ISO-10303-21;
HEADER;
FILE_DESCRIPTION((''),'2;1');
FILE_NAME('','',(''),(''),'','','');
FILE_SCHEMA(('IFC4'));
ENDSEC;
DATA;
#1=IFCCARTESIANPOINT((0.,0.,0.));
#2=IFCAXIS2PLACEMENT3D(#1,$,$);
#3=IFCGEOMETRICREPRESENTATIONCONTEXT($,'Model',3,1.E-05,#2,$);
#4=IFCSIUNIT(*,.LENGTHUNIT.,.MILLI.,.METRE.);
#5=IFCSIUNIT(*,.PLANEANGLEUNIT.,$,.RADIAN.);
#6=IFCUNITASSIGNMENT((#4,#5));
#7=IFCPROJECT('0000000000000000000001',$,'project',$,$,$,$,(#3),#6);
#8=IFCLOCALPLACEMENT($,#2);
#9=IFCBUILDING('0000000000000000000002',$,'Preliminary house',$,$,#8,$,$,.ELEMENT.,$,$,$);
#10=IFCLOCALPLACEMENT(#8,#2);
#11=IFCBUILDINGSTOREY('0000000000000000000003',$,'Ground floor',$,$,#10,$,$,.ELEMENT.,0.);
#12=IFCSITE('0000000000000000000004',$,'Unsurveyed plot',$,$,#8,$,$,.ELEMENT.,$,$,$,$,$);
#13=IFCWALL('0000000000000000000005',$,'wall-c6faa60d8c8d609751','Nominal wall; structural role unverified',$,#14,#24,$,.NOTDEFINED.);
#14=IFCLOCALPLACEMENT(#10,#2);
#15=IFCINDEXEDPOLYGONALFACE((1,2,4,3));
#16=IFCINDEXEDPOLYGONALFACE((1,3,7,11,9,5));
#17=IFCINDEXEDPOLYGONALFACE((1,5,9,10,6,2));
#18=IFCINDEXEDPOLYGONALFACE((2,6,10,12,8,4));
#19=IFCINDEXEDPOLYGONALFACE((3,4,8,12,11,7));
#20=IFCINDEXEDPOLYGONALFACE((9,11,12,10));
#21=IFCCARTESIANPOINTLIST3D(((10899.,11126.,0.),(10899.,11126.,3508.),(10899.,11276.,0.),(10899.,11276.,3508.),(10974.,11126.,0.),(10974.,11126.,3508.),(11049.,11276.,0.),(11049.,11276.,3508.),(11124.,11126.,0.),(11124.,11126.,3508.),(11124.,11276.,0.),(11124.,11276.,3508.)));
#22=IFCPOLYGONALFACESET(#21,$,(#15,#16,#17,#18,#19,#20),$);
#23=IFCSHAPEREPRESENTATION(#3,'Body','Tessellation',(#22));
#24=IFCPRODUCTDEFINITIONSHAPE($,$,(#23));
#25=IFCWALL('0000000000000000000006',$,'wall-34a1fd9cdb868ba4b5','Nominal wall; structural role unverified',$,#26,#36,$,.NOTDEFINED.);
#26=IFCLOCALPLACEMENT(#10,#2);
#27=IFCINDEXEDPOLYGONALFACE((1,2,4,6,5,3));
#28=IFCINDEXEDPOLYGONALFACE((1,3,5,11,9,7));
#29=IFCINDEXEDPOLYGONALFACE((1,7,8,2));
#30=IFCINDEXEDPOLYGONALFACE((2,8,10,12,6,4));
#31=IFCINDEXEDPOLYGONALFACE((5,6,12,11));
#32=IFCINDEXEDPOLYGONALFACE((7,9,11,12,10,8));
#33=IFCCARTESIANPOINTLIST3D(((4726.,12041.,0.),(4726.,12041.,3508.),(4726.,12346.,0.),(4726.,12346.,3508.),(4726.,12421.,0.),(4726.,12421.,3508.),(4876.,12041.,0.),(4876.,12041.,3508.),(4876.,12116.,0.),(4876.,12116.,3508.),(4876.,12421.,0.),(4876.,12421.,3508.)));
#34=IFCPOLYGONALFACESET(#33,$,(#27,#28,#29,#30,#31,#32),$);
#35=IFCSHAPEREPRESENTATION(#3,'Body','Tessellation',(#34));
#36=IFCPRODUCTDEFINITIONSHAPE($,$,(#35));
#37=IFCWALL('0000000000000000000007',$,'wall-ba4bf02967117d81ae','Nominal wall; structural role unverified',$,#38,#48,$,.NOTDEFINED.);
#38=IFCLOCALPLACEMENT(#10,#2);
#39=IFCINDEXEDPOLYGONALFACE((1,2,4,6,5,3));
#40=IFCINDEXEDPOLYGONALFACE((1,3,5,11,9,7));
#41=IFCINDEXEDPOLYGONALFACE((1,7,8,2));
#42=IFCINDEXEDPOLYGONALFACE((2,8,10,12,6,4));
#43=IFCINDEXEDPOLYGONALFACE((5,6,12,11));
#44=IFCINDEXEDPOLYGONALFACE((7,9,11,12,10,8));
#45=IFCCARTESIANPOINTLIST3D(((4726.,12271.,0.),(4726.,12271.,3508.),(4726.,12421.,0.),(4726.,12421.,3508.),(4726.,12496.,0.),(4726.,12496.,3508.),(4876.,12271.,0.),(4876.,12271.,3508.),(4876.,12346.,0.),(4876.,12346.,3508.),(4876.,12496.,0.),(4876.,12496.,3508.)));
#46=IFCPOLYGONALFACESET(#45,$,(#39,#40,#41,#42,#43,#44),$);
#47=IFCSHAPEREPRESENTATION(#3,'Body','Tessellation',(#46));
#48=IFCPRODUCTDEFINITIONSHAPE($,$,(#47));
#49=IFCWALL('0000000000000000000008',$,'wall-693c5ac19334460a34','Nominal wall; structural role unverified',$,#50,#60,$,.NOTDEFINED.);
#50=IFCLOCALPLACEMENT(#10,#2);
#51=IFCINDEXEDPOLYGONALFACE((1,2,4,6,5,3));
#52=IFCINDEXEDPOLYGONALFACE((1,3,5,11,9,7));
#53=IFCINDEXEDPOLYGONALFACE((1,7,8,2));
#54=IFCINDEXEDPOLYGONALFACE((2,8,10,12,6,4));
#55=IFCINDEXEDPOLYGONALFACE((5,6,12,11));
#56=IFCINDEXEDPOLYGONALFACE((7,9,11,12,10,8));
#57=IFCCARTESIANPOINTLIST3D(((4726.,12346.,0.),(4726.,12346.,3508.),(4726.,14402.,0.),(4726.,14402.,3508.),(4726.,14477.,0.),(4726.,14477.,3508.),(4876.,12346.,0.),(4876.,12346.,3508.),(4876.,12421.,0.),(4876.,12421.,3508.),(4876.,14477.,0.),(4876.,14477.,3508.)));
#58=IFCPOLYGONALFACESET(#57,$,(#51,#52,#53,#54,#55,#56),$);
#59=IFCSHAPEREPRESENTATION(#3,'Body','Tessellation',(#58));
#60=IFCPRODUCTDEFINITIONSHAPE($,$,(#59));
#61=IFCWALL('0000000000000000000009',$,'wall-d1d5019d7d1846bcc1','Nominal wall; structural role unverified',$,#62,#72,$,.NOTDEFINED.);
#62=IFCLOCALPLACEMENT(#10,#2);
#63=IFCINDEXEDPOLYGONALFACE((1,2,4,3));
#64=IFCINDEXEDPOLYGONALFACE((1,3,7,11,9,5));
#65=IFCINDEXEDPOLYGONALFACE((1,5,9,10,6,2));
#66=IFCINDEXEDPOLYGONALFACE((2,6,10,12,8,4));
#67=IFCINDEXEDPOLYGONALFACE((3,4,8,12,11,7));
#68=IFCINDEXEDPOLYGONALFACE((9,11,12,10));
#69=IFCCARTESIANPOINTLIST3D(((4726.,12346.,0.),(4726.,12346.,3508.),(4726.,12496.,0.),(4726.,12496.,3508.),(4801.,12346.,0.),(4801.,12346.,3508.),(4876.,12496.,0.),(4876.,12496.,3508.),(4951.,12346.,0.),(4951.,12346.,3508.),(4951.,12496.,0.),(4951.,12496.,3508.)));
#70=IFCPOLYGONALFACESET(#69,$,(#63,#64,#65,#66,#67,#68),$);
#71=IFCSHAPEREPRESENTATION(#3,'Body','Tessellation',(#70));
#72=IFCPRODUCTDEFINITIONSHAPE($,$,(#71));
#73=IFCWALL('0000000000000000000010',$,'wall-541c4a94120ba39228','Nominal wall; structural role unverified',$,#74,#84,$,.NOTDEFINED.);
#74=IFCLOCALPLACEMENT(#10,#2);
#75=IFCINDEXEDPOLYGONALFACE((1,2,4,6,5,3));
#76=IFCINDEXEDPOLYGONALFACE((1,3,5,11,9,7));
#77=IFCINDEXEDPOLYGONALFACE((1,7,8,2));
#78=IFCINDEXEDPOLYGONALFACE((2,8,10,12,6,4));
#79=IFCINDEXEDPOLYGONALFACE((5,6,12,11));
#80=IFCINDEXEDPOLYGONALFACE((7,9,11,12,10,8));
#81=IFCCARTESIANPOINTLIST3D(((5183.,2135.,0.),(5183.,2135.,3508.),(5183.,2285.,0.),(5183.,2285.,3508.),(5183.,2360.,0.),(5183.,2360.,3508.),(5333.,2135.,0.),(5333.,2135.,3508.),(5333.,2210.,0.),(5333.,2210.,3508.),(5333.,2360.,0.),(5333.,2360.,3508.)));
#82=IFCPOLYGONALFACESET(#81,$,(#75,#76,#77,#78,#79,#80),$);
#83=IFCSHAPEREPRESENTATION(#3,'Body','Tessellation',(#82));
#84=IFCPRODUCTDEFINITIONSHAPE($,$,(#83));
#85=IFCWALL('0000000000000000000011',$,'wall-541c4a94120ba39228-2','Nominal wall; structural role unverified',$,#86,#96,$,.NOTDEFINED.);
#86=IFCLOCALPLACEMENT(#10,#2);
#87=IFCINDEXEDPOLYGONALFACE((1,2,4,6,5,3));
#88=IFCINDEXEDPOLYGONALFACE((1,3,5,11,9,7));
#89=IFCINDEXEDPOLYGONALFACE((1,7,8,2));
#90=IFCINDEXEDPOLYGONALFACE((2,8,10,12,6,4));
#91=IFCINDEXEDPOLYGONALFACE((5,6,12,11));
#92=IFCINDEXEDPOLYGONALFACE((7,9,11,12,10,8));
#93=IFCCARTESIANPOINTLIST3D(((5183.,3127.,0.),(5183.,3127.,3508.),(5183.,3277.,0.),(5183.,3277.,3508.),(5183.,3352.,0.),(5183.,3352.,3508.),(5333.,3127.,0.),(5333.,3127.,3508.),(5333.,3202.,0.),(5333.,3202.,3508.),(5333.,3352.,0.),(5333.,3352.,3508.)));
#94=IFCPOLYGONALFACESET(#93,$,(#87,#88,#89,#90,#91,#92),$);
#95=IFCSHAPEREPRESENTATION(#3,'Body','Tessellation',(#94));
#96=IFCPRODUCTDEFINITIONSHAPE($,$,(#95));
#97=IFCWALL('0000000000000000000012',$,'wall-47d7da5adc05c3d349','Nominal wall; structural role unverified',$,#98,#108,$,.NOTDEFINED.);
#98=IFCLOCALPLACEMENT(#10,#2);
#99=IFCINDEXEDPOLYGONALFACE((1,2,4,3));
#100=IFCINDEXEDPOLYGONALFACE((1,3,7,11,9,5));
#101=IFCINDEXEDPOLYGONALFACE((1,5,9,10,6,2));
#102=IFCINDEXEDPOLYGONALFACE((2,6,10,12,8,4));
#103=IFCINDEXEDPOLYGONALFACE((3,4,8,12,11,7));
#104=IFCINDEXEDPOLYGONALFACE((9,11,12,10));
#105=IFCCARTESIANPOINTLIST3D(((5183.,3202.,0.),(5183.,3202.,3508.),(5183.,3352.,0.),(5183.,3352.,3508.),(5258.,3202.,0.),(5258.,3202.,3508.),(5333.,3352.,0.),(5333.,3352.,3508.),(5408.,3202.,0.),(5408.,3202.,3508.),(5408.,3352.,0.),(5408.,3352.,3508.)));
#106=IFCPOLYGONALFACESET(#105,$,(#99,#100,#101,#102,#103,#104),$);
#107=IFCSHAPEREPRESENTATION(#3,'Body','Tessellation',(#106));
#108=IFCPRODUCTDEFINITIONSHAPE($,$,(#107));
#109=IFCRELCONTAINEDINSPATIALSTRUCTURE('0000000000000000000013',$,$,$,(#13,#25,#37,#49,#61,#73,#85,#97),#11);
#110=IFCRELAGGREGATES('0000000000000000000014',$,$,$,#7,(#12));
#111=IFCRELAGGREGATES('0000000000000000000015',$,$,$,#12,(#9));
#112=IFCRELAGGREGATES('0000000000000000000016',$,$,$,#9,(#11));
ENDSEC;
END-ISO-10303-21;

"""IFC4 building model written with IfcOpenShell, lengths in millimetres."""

from ifc_helpers import new_model, si_unit, origin, place, context, project, spatial, polyline, outline, extrude, element, save


model = new_model("IFC4")

# Units and contexts
model_context = context("Model", 3, precision=1e-05, world=origin())
ifc_project = project(units=[si_unit("LENGTHUNIT", "METRE", prefix="MILLI"), si_unit("PLANEANGLEUNIT", "RADIAN")], contexts=[model_context])

# Site, building, storey
placement_1 = place(None, origin())
site = spatial("IfcSite", under=ifc_project, at=placement_1, Name="Unsurveyed plot", CompositionType="ELEMENT")
building = spatial("IfcBuilding", under=site, at=placement_1, Name="Preliminary house", CompositionType="ELEMENT")
placement_2 = place(placement_1, origin())
storey = spatial("IfcBuildingStorey", under=building, at=placement_2, Name="Ground floor", CompositionType="ELEMENT", Elevation=0.0)

# Walls
element("IfcWall", 1, at=placement_2, inside=storey, Name="wall-c6faa60d8c8d609751", Description="Nominal wall; structural role unverified", PredefinedType="NOTDEFINED", context=model_context, shape_type="SweptSolid", body=[
    extrude(outline(polyline([(11049.0, 11276.0), (11124.0, 11276.0), (11124.0, 11126.0), (10974.0, 11126.0), (10899.0, 11126.0), (10899.0, 11276.0), (11049.0, 11276.0)])), origin(), (0.0, 0.0, 1.0), 3508.0),
])
element("IfcWall", 2, at=placement_2, inside=storey, Name="wall-34a1fd9cdb868ba4b5", Description="Nominal wall; structural role unverified", PredefinedType="NOTDEFINED", context=model_context, shape_type="SweptSolid", body=[
    extrude(outline(polyline([(4726.0, 12346.0), (4726.0, 12421.0), (4876.0, 12421.0), (4876.0, 12116.0), (4876.0, 12041.0), (4726.0, 12041.0), (4726.0, 12346.0)])), origin(), (0.0, 0.0, 1.0), 3508.0),
])
element("IfcWall", 3, at=placement_2, inside=storey, Name="wall-ba4bf02967117d81ae", Description="Nominal wall; structural role unverified", PredefinedType="NOTDEFINED", context=model_context, shape_type="SweptSolid", body=[
    extrude(outline(polyline([(4726.0, 12421.0), (4726.0, 12496.0), (4876.0, 12496.0), (4876.0, 12346.0), (4876.0, 12271.0), (4726.0, 12271.0), (4726.0, 12421.0)])), origin(), (0.0, 0.0, 1.0), 3508.0),
])
element("IfcWall", 4, at=placement_2, inside=storey, Name="wall-693c5ac19334460a34", Description="Nominal wall; structural role unverified", PredefinedType="NOTDEFINED", context=model_context, shape_type="SweptSolid", body=[
    extrude(outline(polyline([(4726.0, 14402.0), (4726.0, 14477.0), (4876.0, 14477.0), (4876.0, 12421.0), (4876.0, 12346.0), (4726.0, 12346.0), (4726.0, 14402.0)])), origin(), (0.0, 0.0, 1.0), 3508.0),
])
element("IfcWall", 5, at=placement_2, inside=storey, Name="wall-d1d5019d7d1846bcc1", Description="Nominal wall; structural role unverified", PredefinedType="NOTDEFINED", context=model_context, shape_type="SweptSolid", body=[
    extrude(outline(polyline([(4876.0, 12496.0), (4951.0, 12496.0), (4951.0, 12346.0), (4801.0, 12346.0), (4726.0, 12346.0), (4726.0, 12496.0), (4876.0, 12496.0)])), origin(), (0.0, 0.0, 1.0), 3508.0),
])

# Wall
element("IfcWall", 6, at=placement_2, inside=storey, Name="wall-541c4a94120ba39228", Description="Nominal wall; structural role unverified", PredefinedType="NOTDEFINED", context=model_context, shape_type="SweptSolid", body=[
    extrude(outline(polyline([(5183.0, 2285.0), (5183.0, 2360.0), (5333.0, 2360.0), (5333.0, 2210.0), (5333.0, 2135.0), (5183.0, 2135.0), (5183.0, 2285.0)])), origin(), (0.0, 0.0, 1.0), 3508.0),
])

# Wall
element("IfcWall", 7, at=placement_2, inside=storey, Name="wall-541c4a94120ba39228-2", Description="Nominal wall; structural role unverified", PredefinedType="NOTDEFINED", context=model_context, shape_type="SweptSolid", body=[
    extrude(outline(polyline([(5183.0, 3277.0), (5183.0, 3352.0), (5333.0, 3352.0), (5333.0, 3202.0), (5333.0, 3127.0), (5183.0, 3127.0), (5183.0, 3277.0)])), origin(), (0.0, 0.0, 1.0), 3508.0),
])

# Wall
element("IfcWall", 8, at=placement_2, inside=storey, Name="wall-47d7da5adc05c3d349", Description="Nominal wall; structural role unverified", PredefinedType="NOTDEFINED", context=model_context, shape_type="SweptSolid", body=[
    extrude(outline(polyline([(5333.0, 3352.0), (5408.0, 3352.0), (5408.0, 3202.0), (5258.0, 3202.0), (5183.0, 3202.0), (5183.0, 3352.0), (5333.0, 3352.0)])), origin(), (0.0, 0.0, 1.0), 3508.0),
])

save(model, "model.ifc")
